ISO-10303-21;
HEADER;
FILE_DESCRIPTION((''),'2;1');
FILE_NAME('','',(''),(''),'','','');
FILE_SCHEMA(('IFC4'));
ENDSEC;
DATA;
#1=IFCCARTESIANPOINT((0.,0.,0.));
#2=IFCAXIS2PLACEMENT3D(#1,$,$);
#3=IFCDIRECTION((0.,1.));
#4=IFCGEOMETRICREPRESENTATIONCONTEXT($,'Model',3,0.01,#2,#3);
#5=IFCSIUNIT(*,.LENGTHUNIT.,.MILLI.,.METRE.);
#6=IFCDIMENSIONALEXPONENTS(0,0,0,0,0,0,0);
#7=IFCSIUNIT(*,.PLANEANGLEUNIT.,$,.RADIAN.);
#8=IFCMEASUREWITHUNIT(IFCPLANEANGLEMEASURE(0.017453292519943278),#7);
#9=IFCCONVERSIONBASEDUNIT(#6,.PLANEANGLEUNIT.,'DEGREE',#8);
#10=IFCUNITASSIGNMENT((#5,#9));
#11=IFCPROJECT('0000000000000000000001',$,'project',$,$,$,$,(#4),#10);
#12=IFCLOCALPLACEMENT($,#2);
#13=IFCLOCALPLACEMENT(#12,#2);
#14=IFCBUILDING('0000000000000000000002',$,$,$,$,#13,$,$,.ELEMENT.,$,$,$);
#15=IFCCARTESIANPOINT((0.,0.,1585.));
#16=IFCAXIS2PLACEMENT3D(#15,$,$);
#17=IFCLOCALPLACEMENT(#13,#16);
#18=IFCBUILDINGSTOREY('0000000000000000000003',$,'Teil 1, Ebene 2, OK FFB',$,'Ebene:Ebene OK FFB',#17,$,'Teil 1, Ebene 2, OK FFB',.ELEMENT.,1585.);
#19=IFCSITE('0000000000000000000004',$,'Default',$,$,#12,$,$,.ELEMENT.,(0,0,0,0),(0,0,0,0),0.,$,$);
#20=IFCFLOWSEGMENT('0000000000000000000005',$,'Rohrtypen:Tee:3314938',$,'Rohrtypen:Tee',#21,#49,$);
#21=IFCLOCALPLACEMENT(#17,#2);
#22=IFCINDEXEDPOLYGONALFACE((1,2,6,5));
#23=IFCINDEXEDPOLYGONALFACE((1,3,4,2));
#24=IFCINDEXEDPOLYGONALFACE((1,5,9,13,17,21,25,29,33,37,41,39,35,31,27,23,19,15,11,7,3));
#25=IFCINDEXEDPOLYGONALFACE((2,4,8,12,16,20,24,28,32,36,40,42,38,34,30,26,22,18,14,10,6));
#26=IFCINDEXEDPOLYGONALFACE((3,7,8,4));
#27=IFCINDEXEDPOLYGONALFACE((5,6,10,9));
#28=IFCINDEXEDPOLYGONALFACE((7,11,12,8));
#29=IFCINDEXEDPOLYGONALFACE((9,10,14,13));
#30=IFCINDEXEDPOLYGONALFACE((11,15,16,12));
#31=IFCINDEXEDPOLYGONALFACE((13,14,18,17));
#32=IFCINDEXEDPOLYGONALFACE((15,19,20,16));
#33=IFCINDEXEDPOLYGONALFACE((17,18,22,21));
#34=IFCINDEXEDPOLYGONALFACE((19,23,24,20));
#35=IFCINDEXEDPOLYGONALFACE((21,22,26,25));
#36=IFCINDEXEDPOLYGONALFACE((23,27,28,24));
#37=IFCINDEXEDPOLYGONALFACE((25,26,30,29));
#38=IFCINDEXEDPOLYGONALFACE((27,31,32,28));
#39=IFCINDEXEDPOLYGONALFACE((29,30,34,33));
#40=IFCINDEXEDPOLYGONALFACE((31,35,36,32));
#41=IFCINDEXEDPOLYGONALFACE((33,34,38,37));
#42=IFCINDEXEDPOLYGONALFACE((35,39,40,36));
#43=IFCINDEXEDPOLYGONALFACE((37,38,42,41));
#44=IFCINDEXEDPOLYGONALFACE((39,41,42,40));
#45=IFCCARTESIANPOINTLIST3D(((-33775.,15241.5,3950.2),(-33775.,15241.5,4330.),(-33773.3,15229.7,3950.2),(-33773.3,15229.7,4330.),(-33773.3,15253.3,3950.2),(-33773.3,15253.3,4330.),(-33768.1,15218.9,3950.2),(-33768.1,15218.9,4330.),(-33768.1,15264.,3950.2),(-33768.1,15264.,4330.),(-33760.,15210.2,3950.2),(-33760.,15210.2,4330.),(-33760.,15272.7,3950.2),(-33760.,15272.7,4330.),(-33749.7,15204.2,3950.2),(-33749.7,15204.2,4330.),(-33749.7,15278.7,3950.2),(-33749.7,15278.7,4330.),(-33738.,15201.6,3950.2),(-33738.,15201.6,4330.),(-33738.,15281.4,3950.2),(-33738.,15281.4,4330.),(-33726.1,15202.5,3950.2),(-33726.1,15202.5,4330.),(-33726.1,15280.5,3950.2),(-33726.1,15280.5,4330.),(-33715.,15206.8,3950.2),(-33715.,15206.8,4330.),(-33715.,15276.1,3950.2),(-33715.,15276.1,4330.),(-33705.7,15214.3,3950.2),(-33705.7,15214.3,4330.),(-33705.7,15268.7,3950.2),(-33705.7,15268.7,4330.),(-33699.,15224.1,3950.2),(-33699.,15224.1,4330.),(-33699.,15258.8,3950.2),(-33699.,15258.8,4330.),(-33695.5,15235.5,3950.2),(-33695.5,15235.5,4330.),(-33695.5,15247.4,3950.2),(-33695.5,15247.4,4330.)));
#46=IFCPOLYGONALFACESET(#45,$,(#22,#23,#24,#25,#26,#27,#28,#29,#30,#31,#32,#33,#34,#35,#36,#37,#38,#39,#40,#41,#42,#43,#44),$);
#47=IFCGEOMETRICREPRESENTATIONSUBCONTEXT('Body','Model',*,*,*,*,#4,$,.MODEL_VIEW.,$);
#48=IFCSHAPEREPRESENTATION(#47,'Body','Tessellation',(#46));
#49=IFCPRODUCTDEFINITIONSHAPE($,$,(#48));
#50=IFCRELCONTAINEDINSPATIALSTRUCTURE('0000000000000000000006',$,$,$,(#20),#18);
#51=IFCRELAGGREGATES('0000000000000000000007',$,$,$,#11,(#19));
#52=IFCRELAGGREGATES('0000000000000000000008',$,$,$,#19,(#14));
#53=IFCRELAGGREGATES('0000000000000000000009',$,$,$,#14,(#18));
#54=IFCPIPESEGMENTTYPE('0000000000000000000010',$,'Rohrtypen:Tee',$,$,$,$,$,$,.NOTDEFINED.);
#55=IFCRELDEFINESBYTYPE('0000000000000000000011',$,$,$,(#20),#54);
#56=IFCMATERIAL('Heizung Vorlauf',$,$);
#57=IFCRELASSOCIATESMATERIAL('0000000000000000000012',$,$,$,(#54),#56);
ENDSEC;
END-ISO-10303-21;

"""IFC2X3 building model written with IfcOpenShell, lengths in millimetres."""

from ifc_helpers import new_model, entity, si_unit, converted_unit, direction, frame, origin, origin_2d_with_axis, place, context, subcontext, project, spatial, circle, extrude, material, type_object, element, save


model = new_model("IFC2X3")

# Units and contexts
model_context = context("Model", 3, precision=0.01, world=origin(), true_north=direction((0.0, 1.0)))
body_context = subcontext(model_context, "Body", "Model", "MODEL_VIEW")
ifc_project = project(units=[si_unit("LENGTHUNIT", "METRE", prefix="MILLI"), converted_unit("PLANEANGLEUNIT", "DEGREE", entity("IfcPlaneAngleMeasure", 0.017453292519943278), si_unit("PLANEANGLEUNIT", "RADIAN"), dimensions=[0, 0, 0, 0, 0, 0, 0])], contexts=[model_context])

# Site, building, storey
site_placement = place(None, origin())
site = spatial("IfcSite", under=ifc_project, at=site_placement, Name="Default", CompositionType="ELEMENT", RefLatitude=(0, 0, 0, 0), RefLongitude=(0, 0, 0, 0), RefElevation=0.0)
building_placement = place(site_placement, origin())
building = spatial("IfcBuilding", under=site, at=building_placement, CompositionType="ELEMENT")
storey_placement = place(building_placement, frame((0.0, 0.0, 1585.0)))
storey = spatial("IfcBuildingStorey", under=building, at=storey_placement, Name="Teil 1, Ebene 2, OK FFB", ObjectType="Ebene:Ebene OK FFB", LongName="Teil 1, Ebene 2, OK FFB", CompositionType="ELEMENT", Elevation=1585.0)

# Flow segment
ifc_material = material(Name="Heizung Vorlauf")
pipe_segment_type = type_object("IfcPipeSegmentType", Name="Rohrtypen:Tee", PredefinedType="NOTDEFINED", material=ifc_material)
flow_segment_1_placement = place(storey_placement, origin())
element("IfcFlowSegment", 1, at=flow_segment_1_placement, inside=storey, type_object=pipe_segment_type, Name="Rohrtypen:Tee:3314938", ObjectType="Rohrtypen:Tee", context=body_context, shape_type="SweptSolid", body=[
    extrude(circle(Radius=40.0, at=origin_2d_with_axis()), frame((-33735.0, 15241.5, 3950.2), z_axis=(0.0, 0.0, 1.0), x_axis=(-1.0, 0.0, 0.0)), (0.0, 0.0, 1.0), 379.8),
])

save(model, "model.ifc")
